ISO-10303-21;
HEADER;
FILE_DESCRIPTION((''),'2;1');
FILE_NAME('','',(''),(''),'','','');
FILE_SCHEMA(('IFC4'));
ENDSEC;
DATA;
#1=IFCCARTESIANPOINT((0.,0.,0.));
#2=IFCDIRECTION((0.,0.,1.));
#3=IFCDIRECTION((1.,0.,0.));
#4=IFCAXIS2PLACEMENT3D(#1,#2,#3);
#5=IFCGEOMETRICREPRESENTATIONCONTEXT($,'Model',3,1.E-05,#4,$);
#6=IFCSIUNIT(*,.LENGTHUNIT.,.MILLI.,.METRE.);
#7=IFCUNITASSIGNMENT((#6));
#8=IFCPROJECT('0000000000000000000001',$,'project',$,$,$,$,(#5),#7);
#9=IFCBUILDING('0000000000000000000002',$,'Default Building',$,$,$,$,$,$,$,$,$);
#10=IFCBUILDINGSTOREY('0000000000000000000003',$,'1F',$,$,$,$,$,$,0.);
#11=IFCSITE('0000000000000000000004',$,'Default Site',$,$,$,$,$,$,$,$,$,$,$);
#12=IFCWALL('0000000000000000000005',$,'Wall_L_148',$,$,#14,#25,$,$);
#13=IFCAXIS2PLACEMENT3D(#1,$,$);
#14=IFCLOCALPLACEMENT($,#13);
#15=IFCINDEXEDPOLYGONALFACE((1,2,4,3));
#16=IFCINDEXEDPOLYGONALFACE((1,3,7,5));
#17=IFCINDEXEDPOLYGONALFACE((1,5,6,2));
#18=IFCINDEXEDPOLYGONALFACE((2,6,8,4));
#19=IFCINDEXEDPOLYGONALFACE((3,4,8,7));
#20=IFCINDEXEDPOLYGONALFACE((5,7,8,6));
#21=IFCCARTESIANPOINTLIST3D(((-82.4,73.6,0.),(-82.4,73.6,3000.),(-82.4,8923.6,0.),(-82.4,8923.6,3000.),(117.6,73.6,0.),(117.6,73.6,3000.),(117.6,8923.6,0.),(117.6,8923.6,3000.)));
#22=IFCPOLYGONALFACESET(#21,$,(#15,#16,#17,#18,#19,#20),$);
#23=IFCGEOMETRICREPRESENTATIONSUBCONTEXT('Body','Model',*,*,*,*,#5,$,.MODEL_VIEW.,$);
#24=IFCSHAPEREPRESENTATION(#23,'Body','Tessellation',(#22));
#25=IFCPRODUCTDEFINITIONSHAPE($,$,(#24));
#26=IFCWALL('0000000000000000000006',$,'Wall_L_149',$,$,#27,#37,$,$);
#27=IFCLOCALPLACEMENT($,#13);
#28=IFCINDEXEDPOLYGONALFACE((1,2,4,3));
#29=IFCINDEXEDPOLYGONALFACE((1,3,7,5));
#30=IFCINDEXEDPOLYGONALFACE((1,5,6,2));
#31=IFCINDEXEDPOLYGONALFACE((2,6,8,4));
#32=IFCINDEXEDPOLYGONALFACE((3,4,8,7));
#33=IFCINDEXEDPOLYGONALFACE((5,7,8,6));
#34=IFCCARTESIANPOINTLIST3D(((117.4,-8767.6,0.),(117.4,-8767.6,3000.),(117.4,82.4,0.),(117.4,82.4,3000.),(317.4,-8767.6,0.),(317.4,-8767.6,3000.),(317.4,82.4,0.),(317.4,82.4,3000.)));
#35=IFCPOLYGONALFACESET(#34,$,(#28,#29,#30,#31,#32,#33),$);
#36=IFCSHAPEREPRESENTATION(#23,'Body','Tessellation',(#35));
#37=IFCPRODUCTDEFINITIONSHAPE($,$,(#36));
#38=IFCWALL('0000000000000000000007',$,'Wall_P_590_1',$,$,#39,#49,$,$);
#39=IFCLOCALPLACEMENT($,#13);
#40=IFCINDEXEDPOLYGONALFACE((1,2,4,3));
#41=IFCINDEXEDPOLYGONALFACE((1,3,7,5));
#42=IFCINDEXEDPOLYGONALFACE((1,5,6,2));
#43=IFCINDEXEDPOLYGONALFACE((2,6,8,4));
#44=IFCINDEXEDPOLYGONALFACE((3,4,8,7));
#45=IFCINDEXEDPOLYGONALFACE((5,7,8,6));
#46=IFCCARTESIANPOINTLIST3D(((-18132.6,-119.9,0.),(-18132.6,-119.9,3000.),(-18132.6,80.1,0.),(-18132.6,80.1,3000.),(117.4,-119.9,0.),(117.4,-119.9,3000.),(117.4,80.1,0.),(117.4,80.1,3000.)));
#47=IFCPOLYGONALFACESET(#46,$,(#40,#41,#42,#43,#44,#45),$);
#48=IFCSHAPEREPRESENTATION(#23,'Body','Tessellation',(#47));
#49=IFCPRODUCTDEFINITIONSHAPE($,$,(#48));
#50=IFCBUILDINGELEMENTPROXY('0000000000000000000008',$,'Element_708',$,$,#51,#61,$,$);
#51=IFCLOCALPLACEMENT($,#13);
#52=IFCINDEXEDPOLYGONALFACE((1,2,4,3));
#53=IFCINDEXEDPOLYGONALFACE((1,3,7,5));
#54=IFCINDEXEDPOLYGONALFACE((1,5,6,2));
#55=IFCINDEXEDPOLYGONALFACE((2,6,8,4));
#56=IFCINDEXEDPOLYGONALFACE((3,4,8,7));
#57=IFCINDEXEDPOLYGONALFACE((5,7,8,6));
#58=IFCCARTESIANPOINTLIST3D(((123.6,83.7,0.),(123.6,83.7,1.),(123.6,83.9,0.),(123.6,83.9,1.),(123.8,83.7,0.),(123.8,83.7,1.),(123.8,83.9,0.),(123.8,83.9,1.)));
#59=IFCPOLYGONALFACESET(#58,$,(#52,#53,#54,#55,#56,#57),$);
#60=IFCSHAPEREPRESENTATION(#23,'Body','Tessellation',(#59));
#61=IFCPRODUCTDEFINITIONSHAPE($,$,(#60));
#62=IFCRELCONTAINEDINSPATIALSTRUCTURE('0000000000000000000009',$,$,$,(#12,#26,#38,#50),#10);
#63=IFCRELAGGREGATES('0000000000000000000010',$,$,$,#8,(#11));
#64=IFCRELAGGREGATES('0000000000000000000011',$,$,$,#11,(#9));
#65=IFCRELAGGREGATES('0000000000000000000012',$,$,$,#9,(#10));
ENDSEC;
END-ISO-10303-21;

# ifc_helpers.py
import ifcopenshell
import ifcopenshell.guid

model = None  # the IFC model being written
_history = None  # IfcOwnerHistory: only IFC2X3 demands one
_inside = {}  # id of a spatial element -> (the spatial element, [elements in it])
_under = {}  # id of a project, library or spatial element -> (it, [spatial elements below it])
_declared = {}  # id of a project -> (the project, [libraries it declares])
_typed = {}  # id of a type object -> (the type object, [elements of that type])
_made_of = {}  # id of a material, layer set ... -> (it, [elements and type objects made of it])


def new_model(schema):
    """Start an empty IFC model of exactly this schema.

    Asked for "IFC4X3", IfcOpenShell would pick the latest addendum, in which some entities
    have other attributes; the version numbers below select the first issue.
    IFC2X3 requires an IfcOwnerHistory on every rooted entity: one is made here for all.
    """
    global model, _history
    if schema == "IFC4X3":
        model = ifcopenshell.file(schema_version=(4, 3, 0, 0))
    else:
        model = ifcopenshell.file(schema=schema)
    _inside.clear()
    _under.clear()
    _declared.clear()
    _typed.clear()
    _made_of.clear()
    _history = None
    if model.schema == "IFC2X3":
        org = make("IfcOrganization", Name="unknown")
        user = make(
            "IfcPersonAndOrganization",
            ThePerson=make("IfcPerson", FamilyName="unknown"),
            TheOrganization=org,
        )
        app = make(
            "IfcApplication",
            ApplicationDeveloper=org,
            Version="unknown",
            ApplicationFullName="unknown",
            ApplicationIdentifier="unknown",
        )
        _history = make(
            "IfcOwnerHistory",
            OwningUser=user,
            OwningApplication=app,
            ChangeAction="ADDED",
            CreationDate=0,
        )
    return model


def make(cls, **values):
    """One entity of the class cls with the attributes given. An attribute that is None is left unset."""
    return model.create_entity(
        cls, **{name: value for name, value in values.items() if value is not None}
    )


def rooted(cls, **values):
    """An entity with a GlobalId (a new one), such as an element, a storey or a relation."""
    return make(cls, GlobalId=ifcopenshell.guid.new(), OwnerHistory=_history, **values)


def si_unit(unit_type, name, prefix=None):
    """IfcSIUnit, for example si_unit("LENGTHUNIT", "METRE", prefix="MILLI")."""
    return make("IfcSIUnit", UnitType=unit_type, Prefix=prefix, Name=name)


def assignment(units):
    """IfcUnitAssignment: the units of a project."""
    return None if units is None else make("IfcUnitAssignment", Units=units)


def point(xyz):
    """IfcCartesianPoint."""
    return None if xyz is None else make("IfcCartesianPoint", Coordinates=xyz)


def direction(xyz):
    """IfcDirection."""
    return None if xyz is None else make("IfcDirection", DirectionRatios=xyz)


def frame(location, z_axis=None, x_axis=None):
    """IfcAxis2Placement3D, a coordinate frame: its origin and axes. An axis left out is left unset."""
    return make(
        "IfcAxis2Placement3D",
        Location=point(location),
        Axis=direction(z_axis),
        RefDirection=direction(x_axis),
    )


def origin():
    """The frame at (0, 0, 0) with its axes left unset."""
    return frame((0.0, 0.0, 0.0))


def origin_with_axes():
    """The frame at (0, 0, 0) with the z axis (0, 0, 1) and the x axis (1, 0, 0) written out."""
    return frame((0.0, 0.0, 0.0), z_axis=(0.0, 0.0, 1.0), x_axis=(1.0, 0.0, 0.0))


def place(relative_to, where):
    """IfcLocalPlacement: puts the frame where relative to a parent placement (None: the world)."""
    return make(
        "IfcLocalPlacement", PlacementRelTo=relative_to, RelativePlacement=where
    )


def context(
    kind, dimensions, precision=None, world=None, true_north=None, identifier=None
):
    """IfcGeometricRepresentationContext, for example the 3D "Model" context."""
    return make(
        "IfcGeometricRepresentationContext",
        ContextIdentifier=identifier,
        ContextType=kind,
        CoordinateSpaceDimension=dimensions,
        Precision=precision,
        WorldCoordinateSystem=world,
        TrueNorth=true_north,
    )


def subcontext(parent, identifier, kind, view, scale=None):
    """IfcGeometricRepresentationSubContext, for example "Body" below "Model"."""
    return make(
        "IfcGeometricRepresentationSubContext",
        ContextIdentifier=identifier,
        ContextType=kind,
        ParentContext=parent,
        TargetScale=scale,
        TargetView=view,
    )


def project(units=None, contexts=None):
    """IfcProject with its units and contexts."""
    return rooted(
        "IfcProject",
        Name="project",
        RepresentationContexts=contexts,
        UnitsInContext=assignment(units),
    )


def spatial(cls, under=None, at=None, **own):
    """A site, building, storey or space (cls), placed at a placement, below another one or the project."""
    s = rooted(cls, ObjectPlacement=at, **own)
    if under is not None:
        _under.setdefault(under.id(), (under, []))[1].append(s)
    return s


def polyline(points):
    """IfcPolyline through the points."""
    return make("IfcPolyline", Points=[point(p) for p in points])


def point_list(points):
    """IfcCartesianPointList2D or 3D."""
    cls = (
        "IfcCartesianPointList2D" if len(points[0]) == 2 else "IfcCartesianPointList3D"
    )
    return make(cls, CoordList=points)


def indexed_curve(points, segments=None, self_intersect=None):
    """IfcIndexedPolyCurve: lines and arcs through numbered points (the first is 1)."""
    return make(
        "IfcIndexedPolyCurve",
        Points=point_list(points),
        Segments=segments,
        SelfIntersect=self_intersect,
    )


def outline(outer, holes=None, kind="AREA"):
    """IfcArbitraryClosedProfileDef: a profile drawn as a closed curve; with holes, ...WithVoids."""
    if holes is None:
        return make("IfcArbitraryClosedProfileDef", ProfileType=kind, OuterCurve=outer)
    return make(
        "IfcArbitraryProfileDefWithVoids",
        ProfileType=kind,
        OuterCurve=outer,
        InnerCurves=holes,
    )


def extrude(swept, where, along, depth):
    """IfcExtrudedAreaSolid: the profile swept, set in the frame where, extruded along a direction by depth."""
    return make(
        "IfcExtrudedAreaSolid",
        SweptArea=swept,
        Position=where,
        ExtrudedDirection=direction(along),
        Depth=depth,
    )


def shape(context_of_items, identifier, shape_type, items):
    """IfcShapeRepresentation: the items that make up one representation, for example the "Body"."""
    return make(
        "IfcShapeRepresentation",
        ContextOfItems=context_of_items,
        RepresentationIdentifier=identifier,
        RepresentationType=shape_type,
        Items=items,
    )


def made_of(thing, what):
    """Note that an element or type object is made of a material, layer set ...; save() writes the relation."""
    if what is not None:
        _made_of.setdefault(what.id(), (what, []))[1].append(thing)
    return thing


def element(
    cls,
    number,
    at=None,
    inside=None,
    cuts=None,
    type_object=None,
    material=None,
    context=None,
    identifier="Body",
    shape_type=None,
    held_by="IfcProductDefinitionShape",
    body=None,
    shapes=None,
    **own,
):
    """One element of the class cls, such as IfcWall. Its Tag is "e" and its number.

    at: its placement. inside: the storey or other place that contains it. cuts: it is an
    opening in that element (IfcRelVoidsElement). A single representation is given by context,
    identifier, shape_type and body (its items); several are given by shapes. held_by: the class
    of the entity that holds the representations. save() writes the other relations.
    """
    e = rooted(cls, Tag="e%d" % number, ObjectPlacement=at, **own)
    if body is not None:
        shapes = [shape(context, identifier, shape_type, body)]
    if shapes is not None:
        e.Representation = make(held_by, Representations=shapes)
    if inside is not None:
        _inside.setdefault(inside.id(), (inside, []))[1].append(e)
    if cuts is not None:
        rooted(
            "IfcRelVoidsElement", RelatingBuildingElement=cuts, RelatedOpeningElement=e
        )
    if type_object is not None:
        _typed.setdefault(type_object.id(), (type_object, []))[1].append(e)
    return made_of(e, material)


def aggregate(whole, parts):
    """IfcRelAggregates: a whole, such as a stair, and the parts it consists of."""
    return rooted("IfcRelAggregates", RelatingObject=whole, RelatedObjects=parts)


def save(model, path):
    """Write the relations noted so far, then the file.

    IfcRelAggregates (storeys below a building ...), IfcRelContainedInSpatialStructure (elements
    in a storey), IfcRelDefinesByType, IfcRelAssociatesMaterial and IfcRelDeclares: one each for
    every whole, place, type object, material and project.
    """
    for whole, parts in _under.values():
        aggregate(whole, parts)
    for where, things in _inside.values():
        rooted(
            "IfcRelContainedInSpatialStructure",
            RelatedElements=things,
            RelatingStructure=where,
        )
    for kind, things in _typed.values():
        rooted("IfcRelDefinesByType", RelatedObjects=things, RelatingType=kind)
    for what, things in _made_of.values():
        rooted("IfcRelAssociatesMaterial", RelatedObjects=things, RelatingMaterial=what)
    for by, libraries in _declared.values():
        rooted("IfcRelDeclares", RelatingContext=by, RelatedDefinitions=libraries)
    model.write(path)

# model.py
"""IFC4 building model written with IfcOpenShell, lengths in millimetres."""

from ifc_helpers import new_model, si_unit, frame, origin, origin_with_axes, place, context, subcontext, project, spatial, polyline, indexed_curve, outline, extrude, element, save


model = new_model("IFC4")

# Units and contexts
model_context = context("Model", 3, precision=1e-05, world=origin_with_axes())
body_context = subcontext(model_context, "Body", "Model", "MODEL_VIEW")
ifc_project = project(units=[si_unit("LENGTHUNIT", "METRE", prefix="MILLI")], contexts=[model_context])

# Site, building, storey
site = spatial("IfcSite", under=ifc_project, Name="Default Site")
building = spatial("IfcBuilding", under=site, Name="Default Building")
storey = spatial("IfcBuildingStorey", under=building, Name="1F", Elevation=0.0)

# Walls
for number, where, z_axis, x_axis, name in (
    (1, (117.6, 73.6, 0.0), (0.0, 0.0, 1.0), (0.0, 1.0, 0.0), "Wall_L_148"),
    (2, (117.4, 82.4, 0.0), (0.0, 0.0, 1.0), (0.0, -1.0, 0.0), "Wall_L_149"),
):
    element("IfcWall", number, at=place(None, frame(where, z_axis=z_axis, x_axis=x_axis)), inside=storey, Name=name, context=body_context, shape_type="SweptSolid", body=[
        extrude(outline(indexed_curve([(0.0, 0.0), (0.0, 200.0), (8850.0, 200.0), (8850.0, 0.0), (0.0, 0.0)], self_intersect=False)), origin_with_axes(), (0.0, 0.0, 1.0), 3000.0),
    ])
wall_placement = place(None, frame((117.4, 80.1, 0.0), z_axis=(0.0, 0.0, 1.0), x_axis=(-1.0, 0.0, 0.0)))
element("IfcWall", 3, at=wall_placement, inside=storey, Name="Wall_P_590_1", context=body_context, shape_type="SweptSolid", body=[
    extrude(outline(indexed_curve([(0.0, 0.0), (0.0, 200.0), (18250.0, 200.0), (18250.0, 0.0), (0.0, 0.0)], self_intersect=False)), origin_with_axes(), (0.0, 0.0, 1.0), 3000.0),
])

# Building element proxy
proxy_1_placement = place(None, frame((123.7, 83.8, 0.0), z_axis=(0.0, 0.0, 1.0), x_axis=(1.0, 0.0, 0.0)))
element("IfcBuildingElementProxy", 4, at=proxy_1_placement, inside=storey, Name="Element_708", context=body_context, shape_type="SweptSolid", body=[
    extrude(outline(polyline([(-0.1, -0.1), (0.1, -0.1), (0.1, 0.1), (-0.1, 0.1), (-0.1, -0.1)])), origin(), (0.0, 0.0, 1.0), 1.0),
])

save(model, "model.ifc")
